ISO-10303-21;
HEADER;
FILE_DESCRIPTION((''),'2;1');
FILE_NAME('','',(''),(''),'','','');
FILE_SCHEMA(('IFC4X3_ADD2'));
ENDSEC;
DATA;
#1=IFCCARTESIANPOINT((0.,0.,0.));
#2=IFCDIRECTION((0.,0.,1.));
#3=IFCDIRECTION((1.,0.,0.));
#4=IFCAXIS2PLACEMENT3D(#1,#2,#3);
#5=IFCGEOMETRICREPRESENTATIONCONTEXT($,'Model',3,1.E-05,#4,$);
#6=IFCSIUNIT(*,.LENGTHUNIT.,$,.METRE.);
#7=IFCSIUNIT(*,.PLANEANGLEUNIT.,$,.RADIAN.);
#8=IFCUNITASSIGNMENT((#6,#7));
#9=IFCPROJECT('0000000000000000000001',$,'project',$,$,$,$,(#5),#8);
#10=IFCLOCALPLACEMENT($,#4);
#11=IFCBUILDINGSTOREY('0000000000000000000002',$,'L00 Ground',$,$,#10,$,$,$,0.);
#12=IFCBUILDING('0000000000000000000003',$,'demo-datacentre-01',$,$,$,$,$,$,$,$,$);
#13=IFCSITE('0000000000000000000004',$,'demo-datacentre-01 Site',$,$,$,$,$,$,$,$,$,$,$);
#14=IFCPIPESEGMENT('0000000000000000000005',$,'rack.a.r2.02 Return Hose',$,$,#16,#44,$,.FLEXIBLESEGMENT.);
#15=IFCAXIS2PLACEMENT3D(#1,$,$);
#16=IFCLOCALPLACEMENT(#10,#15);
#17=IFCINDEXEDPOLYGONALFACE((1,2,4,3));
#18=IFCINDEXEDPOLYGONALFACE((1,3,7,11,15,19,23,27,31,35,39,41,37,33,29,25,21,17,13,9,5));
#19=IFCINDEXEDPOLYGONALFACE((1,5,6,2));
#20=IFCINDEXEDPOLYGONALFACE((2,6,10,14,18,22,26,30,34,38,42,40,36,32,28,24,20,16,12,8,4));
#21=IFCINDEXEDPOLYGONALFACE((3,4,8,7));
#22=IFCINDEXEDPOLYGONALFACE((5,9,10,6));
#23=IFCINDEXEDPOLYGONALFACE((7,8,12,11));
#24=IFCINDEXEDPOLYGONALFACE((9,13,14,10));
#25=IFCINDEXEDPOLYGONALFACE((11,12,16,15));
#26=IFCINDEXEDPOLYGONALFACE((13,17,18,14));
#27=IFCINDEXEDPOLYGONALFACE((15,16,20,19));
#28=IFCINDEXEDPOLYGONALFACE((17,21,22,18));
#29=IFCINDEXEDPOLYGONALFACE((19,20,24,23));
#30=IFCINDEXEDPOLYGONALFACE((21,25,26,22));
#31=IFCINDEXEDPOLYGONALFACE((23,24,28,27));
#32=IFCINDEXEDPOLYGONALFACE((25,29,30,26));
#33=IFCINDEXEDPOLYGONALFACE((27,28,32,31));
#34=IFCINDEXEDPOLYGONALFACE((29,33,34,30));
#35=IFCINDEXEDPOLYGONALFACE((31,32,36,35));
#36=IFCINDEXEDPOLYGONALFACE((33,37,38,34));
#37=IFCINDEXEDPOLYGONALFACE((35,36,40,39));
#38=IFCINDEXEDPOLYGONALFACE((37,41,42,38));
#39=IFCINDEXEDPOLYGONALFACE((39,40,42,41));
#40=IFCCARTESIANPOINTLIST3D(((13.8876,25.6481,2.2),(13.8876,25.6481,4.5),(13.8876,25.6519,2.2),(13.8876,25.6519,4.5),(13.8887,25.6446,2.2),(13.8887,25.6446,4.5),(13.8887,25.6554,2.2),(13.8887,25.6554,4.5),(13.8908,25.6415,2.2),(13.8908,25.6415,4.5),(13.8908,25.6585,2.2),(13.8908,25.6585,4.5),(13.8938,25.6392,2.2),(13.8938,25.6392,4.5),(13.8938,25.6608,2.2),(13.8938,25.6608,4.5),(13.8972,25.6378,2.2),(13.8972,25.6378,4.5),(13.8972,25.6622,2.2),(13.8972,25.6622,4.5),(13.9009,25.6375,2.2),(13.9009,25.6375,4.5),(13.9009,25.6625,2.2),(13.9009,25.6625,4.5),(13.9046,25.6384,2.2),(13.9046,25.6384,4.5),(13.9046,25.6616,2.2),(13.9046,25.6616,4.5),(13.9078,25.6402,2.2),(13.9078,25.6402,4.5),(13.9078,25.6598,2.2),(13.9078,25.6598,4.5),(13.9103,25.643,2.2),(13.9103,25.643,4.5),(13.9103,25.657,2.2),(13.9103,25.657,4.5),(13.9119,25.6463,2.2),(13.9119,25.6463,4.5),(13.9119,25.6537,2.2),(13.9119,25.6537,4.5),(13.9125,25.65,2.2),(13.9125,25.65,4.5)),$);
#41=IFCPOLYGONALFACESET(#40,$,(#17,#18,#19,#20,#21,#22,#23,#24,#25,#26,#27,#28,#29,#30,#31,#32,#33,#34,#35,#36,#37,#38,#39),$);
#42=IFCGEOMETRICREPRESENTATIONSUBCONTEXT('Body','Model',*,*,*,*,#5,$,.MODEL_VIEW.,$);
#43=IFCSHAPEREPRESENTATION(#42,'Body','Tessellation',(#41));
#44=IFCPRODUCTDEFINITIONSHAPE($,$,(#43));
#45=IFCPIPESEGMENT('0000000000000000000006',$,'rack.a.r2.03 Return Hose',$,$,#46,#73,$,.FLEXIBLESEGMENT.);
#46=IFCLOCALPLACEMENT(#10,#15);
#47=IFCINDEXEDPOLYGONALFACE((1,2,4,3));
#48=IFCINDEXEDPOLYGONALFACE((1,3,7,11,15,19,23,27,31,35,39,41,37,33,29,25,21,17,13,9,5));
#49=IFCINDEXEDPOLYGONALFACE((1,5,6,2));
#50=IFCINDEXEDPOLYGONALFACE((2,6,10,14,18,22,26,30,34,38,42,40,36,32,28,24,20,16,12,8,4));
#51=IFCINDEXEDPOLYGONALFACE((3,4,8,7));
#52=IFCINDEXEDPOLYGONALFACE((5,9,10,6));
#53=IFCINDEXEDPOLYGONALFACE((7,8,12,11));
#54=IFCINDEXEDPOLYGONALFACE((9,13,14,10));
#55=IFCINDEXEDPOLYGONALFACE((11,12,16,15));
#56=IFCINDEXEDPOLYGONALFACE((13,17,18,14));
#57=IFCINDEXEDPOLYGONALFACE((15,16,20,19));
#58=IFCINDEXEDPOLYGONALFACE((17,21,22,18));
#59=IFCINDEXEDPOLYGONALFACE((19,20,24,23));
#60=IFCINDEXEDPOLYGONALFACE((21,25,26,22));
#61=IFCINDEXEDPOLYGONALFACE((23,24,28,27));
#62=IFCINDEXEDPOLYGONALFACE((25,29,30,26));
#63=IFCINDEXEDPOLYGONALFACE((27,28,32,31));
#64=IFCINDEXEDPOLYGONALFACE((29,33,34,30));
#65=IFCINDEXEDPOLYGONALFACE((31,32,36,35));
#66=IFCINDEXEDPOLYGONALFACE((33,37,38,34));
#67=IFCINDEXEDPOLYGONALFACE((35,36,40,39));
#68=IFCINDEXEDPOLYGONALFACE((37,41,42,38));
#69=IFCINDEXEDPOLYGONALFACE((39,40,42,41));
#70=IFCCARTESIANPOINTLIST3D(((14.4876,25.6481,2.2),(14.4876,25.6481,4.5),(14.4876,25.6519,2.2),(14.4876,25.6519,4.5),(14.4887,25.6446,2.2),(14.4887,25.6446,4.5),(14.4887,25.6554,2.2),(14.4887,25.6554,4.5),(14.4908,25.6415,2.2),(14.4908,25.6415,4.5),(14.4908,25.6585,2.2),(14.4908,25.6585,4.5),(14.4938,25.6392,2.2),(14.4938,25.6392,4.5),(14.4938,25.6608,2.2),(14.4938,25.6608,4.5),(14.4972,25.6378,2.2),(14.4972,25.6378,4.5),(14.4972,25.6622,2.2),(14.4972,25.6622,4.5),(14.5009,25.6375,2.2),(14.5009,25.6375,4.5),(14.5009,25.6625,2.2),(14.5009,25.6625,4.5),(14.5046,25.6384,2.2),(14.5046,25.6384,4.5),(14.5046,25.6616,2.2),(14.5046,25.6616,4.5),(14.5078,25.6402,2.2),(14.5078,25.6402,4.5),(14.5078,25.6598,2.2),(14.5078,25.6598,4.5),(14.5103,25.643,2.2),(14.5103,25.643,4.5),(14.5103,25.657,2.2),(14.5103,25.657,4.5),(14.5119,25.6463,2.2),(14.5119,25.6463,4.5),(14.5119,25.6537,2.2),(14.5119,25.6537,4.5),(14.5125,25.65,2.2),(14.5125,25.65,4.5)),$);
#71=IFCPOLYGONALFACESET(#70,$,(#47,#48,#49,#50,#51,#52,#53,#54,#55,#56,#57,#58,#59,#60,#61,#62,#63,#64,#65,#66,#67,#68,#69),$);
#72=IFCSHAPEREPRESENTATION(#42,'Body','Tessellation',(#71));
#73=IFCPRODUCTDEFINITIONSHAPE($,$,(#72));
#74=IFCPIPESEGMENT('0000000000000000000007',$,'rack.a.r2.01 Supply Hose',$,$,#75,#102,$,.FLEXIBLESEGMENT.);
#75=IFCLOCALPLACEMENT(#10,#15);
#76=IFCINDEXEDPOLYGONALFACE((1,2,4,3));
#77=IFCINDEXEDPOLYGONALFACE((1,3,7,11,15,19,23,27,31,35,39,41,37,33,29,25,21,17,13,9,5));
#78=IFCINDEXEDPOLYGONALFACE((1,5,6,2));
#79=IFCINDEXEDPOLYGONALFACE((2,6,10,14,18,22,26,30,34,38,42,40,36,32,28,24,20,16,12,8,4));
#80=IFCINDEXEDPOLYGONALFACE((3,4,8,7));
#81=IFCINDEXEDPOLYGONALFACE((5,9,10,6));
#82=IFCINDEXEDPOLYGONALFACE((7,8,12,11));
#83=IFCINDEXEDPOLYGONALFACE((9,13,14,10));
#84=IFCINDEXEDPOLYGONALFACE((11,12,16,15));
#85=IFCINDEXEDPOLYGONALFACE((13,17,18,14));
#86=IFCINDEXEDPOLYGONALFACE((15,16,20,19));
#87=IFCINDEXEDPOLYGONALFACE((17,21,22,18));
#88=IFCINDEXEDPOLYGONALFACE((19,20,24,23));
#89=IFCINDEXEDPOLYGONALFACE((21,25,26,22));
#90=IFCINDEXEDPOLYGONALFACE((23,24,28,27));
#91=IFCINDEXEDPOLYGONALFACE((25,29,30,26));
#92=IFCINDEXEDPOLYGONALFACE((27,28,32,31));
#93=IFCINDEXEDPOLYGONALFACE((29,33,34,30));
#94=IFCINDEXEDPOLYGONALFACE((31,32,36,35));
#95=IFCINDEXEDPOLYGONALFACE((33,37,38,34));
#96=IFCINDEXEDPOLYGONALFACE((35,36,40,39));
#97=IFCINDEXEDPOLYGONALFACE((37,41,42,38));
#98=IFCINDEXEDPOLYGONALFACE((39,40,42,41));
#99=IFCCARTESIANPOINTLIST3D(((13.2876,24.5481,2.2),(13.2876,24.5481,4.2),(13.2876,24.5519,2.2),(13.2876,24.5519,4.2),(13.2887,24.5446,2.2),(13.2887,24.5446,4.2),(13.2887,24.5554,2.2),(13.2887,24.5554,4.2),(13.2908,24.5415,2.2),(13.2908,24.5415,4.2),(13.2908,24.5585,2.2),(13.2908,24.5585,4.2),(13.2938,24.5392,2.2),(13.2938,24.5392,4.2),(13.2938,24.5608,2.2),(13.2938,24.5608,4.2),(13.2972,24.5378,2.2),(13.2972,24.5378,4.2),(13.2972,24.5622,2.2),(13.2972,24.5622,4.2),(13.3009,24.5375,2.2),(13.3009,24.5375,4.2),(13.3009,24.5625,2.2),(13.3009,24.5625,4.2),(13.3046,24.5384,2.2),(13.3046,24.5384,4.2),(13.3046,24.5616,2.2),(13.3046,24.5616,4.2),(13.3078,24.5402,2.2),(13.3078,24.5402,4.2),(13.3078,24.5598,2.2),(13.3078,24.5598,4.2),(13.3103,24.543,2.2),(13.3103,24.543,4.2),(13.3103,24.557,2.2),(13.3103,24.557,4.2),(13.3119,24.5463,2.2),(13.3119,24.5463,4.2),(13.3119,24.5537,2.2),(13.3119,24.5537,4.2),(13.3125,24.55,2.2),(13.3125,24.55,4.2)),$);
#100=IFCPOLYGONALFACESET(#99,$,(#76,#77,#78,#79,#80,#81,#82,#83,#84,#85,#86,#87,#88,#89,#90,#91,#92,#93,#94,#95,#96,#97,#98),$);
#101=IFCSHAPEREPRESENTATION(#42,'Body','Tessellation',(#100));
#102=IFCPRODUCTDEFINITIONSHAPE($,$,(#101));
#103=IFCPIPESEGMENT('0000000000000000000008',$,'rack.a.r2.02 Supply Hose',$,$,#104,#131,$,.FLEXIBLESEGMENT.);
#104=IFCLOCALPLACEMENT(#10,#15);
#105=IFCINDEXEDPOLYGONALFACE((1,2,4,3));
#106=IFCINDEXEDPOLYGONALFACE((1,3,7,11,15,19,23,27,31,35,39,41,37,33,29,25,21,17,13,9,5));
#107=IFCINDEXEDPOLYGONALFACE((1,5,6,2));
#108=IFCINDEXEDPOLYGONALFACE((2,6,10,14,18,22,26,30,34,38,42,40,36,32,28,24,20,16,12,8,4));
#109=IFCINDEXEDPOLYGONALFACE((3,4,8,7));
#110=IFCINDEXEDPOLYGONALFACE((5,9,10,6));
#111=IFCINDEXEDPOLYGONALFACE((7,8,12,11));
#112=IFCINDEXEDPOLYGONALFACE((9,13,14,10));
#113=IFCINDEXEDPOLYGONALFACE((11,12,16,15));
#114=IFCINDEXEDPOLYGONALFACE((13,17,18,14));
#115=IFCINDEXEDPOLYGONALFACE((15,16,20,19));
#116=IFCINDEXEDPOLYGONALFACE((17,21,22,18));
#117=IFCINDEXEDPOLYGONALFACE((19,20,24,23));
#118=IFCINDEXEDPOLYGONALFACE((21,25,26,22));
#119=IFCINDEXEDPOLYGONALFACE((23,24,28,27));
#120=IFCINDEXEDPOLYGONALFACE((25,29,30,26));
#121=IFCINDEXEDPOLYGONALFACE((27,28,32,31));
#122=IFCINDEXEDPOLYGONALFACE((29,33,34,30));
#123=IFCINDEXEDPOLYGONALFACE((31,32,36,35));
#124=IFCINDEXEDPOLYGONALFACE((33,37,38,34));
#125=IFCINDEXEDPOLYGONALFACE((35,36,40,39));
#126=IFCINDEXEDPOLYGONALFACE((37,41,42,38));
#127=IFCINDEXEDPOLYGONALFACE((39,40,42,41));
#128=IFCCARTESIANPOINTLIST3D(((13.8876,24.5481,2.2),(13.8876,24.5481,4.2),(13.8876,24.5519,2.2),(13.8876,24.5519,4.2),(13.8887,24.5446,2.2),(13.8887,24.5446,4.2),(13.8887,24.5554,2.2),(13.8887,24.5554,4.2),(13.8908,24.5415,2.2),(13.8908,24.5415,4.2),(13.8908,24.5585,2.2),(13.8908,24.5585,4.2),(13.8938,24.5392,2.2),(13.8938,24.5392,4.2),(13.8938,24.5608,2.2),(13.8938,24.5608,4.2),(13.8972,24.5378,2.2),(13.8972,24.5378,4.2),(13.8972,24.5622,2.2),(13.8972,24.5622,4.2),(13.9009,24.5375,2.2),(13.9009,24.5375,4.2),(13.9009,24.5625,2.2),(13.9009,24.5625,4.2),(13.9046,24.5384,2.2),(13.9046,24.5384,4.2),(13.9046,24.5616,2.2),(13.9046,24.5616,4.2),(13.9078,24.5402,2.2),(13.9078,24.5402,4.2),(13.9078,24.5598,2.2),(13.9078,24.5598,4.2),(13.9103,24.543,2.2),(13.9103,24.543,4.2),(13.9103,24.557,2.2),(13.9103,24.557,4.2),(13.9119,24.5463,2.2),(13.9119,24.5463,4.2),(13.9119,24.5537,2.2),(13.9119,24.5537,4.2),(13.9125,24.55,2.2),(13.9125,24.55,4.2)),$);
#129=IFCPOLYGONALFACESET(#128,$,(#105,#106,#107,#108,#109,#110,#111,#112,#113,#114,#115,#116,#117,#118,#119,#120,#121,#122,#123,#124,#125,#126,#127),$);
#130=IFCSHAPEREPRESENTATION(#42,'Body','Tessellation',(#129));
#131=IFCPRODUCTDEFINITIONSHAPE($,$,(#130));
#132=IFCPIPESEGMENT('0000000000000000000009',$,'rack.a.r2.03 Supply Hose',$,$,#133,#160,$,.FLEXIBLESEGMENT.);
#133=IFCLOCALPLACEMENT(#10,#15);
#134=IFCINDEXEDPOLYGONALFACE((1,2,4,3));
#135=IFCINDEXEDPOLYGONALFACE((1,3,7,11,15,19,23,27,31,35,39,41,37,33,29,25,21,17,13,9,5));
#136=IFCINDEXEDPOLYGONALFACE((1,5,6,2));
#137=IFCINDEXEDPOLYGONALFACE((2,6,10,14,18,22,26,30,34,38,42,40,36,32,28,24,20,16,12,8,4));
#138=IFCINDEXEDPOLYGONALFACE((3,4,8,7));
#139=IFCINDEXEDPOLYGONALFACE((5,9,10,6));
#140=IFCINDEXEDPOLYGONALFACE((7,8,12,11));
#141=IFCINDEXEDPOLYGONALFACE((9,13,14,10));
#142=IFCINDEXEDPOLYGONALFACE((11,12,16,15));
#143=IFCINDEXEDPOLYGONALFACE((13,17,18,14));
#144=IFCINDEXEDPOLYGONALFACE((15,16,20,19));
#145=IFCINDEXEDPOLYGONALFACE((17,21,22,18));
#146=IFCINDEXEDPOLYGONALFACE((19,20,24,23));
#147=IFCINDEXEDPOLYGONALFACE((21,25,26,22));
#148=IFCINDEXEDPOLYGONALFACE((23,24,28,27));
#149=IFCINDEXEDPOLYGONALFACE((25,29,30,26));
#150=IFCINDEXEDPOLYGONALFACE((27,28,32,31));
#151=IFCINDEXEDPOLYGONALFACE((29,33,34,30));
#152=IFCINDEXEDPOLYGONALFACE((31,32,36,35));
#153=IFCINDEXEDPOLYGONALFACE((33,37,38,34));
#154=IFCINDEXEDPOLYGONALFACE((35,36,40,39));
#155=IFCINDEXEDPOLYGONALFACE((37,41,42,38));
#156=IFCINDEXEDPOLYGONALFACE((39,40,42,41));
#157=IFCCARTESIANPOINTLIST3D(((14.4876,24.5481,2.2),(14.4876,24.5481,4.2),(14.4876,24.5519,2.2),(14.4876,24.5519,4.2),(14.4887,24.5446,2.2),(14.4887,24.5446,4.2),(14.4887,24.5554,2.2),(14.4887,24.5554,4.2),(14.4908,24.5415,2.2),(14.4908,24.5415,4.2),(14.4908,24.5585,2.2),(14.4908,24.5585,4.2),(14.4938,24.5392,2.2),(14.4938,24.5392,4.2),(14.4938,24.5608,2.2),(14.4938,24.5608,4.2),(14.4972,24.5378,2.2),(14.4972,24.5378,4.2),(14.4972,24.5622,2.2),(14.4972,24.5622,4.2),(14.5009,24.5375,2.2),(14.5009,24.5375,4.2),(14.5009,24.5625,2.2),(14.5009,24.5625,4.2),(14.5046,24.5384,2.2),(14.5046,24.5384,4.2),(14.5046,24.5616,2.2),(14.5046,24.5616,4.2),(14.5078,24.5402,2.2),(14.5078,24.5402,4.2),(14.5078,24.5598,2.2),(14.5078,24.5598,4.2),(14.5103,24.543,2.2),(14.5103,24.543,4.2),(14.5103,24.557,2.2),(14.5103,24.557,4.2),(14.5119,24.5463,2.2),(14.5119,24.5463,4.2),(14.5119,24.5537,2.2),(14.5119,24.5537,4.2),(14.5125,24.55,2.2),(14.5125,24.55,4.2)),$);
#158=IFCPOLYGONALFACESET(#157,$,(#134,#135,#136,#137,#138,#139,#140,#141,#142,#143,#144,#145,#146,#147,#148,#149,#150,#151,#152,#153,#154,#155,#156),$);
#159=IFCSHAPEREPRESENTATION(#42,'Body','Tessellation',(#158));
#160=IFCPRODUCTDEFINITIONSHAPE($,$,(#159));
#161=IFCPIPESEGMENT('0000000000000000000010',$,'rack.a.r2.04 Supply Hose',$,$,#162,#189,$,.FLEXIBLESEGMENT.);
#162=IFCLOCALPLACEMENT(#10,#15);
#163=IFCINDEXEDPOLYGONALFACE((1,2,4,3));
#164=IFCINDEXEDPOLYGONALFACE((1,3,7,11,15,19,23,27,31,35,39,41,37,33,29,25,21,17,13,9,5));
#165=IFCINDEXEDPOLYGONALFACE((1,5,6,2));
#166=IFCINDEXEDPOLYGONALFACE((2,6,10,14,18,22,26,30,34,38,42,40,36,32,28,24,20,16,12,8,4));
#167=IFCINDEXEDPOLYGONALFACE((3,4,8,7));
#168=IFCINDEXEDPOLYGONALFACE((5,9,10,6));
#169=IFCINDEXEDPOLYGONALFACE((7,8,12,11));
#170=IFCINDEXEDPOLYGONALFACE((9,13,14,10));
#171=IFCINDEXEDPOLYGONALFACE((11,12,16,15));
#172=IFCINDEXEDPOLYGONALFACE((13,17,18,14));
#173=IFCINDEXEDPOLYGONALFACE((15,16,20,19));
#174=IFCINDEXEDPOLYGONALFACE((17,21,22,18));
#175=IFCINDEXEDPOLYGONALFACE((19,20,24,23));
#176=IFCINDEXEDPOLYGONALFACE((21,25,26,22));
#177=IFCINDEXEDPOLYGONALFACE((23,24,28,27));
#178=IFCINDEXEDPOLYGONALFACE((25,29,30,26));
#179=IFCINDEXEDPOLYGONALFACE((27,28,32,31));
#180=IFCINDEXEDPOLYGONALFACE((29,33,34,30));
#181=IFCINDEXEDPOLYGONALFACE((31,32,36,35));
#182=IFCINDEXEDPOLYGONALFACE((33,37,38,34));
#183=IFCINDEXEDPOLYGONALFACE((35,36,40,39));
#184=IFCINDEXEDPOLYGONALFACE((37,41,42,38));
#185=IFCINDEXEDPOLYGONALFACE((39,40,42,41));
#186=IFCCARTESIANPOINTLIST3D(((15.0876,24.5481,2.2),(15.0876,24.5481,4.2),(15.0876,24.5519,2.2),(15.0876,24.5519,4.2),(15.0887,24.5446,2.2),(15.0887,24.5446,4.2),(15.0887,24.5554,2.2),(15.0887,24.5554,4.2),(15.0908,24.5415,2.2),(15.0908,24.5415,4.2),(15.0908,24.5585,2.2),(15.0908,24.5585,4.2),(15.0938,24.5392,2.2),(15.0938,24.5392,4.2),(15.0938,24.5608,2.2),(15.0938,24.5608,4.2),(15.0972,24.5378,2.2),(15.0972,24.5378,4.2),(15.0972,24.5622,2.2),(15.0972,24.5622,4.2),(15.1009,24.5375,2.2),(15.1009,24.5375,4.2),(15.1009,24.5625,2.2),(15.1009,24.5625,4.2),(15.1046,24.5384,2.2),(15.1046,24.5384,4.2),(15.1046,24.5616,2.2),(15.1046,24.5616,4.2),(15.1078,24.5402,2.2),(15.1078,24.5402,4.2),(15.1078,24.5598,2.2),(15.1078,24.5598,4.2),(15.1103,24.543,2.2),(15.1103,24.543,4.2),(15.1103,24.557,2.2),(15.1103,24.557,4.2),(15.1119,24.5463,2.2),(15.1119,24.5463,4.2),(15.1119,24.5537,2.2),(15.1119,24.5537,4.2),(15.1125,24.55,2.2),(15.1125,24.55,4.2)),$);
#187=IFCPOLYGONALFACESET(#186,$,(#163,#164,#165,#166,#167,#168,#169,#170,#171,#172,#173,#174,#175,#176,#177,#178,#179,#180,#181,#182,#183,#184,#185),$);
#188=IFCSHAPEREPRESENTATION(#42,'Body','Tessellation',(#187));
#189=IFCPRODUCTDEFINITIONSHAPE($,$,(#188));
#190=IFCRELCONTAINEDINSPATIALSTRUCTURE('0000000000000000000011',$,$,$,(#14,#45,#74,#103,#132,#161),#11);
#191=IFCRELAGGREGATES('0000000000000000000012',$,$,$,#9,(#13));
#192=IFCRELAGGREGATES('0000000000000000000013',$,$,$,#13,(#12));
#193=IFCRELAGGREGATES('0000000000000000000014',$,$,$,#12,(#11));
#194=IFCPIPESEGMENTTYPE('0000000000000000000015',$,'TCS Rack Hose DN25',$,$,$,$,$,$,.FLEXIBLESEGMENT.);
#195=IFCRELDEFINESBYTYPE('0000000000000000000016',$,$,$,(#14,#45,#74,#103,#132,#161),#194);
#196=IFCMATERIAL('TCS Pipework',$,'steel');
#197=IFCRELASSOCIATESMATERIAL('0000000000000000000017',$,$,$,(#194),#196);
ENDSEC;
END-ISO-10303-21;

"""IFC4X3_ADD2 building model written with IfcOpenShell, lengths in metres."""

from ifc_helpers import new_model, si_unit, frame, origin_with_axes, place, context, subcontext, project, spatial, circle, extrude, material, type_object, element, save


model = new_model("IFC4X3_ADD2")

# Units and contexts
model_context = context("Model", 3, precision=1e-05, world=origin_with_axes())
body_context = subcontext(model_context, "Body", "Model", "MODEL_VIEW")
ifc_project = project(units=[si_unit("LENGTHUNIT", "METRE"), si_unit("PLANEANGLEUNIT", "RADIAN")], contexts=[model_context])

# Site, building, storey
site = spatial("IfcSite", under=ifc_project, Name="demo-datacentre-01 Site")
building = spatial("IfcBuilding", under=site, Name="demo-datacentre-01")
storey_placement = place(None, origin_with_axes())
storey = spatial("IfcBuildingStorey", under=building, at=storey_placement, Name="L00 Ground", Elevation=0.0)

# Shared definitions
ifc_material = material(Name="TCS Pipework", Category="steel")

# Pipe segments
pipe_segment_type_1 = type_object("IfcPipeSegmentType", Name="TCS Rack Hose DN25", PredefinedType="FLEXIBLESEGMENT", material=ifc_material)
for number, where, z_axis, x_axis, name in (
    (1, (13.9, 25.65, 4.5), (0.0, 0.0, -1.0), (1.0, 0.0, 0.0), "rack.a.r2.02 Return Hose"),
    (2, (14.5, 25.65, 4.5), (0.0, 0.0, -1.0), (1.0, 0.0, 0.0), "rack.a.r2.03 Return Hose"),
):
    element("IfcPipeSegment", number, at=place(storey_placement, frame(where, z_axis=z_axis, x_axis=x_axis)), inside=storey, type_object=pipe_segment_type_1, Name=name, PredefinedType="FLEXIBLESEGMENT", context=body_context, shape_type="SweptSolid", body=[
        extrude(circle(Radius=0.0125), origin_with_axes(), (0.0, 0.0, 1.0), 2.3),
    ])
for number, where, z_axis, x_axis, name in (
    (3, (13.3, 24.55, 4.2), (0.0, 0.0, -1.0), (1.0, 0.0, 0.0), "rack.a.r2.01 Supply Hose"),
    (4, (13.9, 24.55, 4.2), (0.0, 0.0, -1.0), (1.0, 0.0, 0.0), "rack.a.r2.02 Supply Hose"),
    (5, (14.5, 24.55, 4.2), (0.0, 0.0, -1.0), (1.0, 0.0, 0.0), "rack.a.r2.03 Supply Hose"),
    (6, (15.1, 24.55, 4.2), (0.0, 0.0, -1.0), (1.0, 0.0, 0.0), "rack.a.r2.04 Supply Hose"),
):
    element("IfcPipeSegment", number, at=place(storey_placement, frame(where, z_axis=z_axis, x_axis=x_axis)), inside=storey, type_object=pipe_segment_type_1, Name=name, PredefinedType="FLEXIBLESEGMENT", context=body_context, shape_type="SweptSolid", body=[
        extrude(circle(Radius=0.0125), origin_with_axes(), (0.0, 0.0, 1.0), 2.0),
    ])

save(model, "model.ifc")
